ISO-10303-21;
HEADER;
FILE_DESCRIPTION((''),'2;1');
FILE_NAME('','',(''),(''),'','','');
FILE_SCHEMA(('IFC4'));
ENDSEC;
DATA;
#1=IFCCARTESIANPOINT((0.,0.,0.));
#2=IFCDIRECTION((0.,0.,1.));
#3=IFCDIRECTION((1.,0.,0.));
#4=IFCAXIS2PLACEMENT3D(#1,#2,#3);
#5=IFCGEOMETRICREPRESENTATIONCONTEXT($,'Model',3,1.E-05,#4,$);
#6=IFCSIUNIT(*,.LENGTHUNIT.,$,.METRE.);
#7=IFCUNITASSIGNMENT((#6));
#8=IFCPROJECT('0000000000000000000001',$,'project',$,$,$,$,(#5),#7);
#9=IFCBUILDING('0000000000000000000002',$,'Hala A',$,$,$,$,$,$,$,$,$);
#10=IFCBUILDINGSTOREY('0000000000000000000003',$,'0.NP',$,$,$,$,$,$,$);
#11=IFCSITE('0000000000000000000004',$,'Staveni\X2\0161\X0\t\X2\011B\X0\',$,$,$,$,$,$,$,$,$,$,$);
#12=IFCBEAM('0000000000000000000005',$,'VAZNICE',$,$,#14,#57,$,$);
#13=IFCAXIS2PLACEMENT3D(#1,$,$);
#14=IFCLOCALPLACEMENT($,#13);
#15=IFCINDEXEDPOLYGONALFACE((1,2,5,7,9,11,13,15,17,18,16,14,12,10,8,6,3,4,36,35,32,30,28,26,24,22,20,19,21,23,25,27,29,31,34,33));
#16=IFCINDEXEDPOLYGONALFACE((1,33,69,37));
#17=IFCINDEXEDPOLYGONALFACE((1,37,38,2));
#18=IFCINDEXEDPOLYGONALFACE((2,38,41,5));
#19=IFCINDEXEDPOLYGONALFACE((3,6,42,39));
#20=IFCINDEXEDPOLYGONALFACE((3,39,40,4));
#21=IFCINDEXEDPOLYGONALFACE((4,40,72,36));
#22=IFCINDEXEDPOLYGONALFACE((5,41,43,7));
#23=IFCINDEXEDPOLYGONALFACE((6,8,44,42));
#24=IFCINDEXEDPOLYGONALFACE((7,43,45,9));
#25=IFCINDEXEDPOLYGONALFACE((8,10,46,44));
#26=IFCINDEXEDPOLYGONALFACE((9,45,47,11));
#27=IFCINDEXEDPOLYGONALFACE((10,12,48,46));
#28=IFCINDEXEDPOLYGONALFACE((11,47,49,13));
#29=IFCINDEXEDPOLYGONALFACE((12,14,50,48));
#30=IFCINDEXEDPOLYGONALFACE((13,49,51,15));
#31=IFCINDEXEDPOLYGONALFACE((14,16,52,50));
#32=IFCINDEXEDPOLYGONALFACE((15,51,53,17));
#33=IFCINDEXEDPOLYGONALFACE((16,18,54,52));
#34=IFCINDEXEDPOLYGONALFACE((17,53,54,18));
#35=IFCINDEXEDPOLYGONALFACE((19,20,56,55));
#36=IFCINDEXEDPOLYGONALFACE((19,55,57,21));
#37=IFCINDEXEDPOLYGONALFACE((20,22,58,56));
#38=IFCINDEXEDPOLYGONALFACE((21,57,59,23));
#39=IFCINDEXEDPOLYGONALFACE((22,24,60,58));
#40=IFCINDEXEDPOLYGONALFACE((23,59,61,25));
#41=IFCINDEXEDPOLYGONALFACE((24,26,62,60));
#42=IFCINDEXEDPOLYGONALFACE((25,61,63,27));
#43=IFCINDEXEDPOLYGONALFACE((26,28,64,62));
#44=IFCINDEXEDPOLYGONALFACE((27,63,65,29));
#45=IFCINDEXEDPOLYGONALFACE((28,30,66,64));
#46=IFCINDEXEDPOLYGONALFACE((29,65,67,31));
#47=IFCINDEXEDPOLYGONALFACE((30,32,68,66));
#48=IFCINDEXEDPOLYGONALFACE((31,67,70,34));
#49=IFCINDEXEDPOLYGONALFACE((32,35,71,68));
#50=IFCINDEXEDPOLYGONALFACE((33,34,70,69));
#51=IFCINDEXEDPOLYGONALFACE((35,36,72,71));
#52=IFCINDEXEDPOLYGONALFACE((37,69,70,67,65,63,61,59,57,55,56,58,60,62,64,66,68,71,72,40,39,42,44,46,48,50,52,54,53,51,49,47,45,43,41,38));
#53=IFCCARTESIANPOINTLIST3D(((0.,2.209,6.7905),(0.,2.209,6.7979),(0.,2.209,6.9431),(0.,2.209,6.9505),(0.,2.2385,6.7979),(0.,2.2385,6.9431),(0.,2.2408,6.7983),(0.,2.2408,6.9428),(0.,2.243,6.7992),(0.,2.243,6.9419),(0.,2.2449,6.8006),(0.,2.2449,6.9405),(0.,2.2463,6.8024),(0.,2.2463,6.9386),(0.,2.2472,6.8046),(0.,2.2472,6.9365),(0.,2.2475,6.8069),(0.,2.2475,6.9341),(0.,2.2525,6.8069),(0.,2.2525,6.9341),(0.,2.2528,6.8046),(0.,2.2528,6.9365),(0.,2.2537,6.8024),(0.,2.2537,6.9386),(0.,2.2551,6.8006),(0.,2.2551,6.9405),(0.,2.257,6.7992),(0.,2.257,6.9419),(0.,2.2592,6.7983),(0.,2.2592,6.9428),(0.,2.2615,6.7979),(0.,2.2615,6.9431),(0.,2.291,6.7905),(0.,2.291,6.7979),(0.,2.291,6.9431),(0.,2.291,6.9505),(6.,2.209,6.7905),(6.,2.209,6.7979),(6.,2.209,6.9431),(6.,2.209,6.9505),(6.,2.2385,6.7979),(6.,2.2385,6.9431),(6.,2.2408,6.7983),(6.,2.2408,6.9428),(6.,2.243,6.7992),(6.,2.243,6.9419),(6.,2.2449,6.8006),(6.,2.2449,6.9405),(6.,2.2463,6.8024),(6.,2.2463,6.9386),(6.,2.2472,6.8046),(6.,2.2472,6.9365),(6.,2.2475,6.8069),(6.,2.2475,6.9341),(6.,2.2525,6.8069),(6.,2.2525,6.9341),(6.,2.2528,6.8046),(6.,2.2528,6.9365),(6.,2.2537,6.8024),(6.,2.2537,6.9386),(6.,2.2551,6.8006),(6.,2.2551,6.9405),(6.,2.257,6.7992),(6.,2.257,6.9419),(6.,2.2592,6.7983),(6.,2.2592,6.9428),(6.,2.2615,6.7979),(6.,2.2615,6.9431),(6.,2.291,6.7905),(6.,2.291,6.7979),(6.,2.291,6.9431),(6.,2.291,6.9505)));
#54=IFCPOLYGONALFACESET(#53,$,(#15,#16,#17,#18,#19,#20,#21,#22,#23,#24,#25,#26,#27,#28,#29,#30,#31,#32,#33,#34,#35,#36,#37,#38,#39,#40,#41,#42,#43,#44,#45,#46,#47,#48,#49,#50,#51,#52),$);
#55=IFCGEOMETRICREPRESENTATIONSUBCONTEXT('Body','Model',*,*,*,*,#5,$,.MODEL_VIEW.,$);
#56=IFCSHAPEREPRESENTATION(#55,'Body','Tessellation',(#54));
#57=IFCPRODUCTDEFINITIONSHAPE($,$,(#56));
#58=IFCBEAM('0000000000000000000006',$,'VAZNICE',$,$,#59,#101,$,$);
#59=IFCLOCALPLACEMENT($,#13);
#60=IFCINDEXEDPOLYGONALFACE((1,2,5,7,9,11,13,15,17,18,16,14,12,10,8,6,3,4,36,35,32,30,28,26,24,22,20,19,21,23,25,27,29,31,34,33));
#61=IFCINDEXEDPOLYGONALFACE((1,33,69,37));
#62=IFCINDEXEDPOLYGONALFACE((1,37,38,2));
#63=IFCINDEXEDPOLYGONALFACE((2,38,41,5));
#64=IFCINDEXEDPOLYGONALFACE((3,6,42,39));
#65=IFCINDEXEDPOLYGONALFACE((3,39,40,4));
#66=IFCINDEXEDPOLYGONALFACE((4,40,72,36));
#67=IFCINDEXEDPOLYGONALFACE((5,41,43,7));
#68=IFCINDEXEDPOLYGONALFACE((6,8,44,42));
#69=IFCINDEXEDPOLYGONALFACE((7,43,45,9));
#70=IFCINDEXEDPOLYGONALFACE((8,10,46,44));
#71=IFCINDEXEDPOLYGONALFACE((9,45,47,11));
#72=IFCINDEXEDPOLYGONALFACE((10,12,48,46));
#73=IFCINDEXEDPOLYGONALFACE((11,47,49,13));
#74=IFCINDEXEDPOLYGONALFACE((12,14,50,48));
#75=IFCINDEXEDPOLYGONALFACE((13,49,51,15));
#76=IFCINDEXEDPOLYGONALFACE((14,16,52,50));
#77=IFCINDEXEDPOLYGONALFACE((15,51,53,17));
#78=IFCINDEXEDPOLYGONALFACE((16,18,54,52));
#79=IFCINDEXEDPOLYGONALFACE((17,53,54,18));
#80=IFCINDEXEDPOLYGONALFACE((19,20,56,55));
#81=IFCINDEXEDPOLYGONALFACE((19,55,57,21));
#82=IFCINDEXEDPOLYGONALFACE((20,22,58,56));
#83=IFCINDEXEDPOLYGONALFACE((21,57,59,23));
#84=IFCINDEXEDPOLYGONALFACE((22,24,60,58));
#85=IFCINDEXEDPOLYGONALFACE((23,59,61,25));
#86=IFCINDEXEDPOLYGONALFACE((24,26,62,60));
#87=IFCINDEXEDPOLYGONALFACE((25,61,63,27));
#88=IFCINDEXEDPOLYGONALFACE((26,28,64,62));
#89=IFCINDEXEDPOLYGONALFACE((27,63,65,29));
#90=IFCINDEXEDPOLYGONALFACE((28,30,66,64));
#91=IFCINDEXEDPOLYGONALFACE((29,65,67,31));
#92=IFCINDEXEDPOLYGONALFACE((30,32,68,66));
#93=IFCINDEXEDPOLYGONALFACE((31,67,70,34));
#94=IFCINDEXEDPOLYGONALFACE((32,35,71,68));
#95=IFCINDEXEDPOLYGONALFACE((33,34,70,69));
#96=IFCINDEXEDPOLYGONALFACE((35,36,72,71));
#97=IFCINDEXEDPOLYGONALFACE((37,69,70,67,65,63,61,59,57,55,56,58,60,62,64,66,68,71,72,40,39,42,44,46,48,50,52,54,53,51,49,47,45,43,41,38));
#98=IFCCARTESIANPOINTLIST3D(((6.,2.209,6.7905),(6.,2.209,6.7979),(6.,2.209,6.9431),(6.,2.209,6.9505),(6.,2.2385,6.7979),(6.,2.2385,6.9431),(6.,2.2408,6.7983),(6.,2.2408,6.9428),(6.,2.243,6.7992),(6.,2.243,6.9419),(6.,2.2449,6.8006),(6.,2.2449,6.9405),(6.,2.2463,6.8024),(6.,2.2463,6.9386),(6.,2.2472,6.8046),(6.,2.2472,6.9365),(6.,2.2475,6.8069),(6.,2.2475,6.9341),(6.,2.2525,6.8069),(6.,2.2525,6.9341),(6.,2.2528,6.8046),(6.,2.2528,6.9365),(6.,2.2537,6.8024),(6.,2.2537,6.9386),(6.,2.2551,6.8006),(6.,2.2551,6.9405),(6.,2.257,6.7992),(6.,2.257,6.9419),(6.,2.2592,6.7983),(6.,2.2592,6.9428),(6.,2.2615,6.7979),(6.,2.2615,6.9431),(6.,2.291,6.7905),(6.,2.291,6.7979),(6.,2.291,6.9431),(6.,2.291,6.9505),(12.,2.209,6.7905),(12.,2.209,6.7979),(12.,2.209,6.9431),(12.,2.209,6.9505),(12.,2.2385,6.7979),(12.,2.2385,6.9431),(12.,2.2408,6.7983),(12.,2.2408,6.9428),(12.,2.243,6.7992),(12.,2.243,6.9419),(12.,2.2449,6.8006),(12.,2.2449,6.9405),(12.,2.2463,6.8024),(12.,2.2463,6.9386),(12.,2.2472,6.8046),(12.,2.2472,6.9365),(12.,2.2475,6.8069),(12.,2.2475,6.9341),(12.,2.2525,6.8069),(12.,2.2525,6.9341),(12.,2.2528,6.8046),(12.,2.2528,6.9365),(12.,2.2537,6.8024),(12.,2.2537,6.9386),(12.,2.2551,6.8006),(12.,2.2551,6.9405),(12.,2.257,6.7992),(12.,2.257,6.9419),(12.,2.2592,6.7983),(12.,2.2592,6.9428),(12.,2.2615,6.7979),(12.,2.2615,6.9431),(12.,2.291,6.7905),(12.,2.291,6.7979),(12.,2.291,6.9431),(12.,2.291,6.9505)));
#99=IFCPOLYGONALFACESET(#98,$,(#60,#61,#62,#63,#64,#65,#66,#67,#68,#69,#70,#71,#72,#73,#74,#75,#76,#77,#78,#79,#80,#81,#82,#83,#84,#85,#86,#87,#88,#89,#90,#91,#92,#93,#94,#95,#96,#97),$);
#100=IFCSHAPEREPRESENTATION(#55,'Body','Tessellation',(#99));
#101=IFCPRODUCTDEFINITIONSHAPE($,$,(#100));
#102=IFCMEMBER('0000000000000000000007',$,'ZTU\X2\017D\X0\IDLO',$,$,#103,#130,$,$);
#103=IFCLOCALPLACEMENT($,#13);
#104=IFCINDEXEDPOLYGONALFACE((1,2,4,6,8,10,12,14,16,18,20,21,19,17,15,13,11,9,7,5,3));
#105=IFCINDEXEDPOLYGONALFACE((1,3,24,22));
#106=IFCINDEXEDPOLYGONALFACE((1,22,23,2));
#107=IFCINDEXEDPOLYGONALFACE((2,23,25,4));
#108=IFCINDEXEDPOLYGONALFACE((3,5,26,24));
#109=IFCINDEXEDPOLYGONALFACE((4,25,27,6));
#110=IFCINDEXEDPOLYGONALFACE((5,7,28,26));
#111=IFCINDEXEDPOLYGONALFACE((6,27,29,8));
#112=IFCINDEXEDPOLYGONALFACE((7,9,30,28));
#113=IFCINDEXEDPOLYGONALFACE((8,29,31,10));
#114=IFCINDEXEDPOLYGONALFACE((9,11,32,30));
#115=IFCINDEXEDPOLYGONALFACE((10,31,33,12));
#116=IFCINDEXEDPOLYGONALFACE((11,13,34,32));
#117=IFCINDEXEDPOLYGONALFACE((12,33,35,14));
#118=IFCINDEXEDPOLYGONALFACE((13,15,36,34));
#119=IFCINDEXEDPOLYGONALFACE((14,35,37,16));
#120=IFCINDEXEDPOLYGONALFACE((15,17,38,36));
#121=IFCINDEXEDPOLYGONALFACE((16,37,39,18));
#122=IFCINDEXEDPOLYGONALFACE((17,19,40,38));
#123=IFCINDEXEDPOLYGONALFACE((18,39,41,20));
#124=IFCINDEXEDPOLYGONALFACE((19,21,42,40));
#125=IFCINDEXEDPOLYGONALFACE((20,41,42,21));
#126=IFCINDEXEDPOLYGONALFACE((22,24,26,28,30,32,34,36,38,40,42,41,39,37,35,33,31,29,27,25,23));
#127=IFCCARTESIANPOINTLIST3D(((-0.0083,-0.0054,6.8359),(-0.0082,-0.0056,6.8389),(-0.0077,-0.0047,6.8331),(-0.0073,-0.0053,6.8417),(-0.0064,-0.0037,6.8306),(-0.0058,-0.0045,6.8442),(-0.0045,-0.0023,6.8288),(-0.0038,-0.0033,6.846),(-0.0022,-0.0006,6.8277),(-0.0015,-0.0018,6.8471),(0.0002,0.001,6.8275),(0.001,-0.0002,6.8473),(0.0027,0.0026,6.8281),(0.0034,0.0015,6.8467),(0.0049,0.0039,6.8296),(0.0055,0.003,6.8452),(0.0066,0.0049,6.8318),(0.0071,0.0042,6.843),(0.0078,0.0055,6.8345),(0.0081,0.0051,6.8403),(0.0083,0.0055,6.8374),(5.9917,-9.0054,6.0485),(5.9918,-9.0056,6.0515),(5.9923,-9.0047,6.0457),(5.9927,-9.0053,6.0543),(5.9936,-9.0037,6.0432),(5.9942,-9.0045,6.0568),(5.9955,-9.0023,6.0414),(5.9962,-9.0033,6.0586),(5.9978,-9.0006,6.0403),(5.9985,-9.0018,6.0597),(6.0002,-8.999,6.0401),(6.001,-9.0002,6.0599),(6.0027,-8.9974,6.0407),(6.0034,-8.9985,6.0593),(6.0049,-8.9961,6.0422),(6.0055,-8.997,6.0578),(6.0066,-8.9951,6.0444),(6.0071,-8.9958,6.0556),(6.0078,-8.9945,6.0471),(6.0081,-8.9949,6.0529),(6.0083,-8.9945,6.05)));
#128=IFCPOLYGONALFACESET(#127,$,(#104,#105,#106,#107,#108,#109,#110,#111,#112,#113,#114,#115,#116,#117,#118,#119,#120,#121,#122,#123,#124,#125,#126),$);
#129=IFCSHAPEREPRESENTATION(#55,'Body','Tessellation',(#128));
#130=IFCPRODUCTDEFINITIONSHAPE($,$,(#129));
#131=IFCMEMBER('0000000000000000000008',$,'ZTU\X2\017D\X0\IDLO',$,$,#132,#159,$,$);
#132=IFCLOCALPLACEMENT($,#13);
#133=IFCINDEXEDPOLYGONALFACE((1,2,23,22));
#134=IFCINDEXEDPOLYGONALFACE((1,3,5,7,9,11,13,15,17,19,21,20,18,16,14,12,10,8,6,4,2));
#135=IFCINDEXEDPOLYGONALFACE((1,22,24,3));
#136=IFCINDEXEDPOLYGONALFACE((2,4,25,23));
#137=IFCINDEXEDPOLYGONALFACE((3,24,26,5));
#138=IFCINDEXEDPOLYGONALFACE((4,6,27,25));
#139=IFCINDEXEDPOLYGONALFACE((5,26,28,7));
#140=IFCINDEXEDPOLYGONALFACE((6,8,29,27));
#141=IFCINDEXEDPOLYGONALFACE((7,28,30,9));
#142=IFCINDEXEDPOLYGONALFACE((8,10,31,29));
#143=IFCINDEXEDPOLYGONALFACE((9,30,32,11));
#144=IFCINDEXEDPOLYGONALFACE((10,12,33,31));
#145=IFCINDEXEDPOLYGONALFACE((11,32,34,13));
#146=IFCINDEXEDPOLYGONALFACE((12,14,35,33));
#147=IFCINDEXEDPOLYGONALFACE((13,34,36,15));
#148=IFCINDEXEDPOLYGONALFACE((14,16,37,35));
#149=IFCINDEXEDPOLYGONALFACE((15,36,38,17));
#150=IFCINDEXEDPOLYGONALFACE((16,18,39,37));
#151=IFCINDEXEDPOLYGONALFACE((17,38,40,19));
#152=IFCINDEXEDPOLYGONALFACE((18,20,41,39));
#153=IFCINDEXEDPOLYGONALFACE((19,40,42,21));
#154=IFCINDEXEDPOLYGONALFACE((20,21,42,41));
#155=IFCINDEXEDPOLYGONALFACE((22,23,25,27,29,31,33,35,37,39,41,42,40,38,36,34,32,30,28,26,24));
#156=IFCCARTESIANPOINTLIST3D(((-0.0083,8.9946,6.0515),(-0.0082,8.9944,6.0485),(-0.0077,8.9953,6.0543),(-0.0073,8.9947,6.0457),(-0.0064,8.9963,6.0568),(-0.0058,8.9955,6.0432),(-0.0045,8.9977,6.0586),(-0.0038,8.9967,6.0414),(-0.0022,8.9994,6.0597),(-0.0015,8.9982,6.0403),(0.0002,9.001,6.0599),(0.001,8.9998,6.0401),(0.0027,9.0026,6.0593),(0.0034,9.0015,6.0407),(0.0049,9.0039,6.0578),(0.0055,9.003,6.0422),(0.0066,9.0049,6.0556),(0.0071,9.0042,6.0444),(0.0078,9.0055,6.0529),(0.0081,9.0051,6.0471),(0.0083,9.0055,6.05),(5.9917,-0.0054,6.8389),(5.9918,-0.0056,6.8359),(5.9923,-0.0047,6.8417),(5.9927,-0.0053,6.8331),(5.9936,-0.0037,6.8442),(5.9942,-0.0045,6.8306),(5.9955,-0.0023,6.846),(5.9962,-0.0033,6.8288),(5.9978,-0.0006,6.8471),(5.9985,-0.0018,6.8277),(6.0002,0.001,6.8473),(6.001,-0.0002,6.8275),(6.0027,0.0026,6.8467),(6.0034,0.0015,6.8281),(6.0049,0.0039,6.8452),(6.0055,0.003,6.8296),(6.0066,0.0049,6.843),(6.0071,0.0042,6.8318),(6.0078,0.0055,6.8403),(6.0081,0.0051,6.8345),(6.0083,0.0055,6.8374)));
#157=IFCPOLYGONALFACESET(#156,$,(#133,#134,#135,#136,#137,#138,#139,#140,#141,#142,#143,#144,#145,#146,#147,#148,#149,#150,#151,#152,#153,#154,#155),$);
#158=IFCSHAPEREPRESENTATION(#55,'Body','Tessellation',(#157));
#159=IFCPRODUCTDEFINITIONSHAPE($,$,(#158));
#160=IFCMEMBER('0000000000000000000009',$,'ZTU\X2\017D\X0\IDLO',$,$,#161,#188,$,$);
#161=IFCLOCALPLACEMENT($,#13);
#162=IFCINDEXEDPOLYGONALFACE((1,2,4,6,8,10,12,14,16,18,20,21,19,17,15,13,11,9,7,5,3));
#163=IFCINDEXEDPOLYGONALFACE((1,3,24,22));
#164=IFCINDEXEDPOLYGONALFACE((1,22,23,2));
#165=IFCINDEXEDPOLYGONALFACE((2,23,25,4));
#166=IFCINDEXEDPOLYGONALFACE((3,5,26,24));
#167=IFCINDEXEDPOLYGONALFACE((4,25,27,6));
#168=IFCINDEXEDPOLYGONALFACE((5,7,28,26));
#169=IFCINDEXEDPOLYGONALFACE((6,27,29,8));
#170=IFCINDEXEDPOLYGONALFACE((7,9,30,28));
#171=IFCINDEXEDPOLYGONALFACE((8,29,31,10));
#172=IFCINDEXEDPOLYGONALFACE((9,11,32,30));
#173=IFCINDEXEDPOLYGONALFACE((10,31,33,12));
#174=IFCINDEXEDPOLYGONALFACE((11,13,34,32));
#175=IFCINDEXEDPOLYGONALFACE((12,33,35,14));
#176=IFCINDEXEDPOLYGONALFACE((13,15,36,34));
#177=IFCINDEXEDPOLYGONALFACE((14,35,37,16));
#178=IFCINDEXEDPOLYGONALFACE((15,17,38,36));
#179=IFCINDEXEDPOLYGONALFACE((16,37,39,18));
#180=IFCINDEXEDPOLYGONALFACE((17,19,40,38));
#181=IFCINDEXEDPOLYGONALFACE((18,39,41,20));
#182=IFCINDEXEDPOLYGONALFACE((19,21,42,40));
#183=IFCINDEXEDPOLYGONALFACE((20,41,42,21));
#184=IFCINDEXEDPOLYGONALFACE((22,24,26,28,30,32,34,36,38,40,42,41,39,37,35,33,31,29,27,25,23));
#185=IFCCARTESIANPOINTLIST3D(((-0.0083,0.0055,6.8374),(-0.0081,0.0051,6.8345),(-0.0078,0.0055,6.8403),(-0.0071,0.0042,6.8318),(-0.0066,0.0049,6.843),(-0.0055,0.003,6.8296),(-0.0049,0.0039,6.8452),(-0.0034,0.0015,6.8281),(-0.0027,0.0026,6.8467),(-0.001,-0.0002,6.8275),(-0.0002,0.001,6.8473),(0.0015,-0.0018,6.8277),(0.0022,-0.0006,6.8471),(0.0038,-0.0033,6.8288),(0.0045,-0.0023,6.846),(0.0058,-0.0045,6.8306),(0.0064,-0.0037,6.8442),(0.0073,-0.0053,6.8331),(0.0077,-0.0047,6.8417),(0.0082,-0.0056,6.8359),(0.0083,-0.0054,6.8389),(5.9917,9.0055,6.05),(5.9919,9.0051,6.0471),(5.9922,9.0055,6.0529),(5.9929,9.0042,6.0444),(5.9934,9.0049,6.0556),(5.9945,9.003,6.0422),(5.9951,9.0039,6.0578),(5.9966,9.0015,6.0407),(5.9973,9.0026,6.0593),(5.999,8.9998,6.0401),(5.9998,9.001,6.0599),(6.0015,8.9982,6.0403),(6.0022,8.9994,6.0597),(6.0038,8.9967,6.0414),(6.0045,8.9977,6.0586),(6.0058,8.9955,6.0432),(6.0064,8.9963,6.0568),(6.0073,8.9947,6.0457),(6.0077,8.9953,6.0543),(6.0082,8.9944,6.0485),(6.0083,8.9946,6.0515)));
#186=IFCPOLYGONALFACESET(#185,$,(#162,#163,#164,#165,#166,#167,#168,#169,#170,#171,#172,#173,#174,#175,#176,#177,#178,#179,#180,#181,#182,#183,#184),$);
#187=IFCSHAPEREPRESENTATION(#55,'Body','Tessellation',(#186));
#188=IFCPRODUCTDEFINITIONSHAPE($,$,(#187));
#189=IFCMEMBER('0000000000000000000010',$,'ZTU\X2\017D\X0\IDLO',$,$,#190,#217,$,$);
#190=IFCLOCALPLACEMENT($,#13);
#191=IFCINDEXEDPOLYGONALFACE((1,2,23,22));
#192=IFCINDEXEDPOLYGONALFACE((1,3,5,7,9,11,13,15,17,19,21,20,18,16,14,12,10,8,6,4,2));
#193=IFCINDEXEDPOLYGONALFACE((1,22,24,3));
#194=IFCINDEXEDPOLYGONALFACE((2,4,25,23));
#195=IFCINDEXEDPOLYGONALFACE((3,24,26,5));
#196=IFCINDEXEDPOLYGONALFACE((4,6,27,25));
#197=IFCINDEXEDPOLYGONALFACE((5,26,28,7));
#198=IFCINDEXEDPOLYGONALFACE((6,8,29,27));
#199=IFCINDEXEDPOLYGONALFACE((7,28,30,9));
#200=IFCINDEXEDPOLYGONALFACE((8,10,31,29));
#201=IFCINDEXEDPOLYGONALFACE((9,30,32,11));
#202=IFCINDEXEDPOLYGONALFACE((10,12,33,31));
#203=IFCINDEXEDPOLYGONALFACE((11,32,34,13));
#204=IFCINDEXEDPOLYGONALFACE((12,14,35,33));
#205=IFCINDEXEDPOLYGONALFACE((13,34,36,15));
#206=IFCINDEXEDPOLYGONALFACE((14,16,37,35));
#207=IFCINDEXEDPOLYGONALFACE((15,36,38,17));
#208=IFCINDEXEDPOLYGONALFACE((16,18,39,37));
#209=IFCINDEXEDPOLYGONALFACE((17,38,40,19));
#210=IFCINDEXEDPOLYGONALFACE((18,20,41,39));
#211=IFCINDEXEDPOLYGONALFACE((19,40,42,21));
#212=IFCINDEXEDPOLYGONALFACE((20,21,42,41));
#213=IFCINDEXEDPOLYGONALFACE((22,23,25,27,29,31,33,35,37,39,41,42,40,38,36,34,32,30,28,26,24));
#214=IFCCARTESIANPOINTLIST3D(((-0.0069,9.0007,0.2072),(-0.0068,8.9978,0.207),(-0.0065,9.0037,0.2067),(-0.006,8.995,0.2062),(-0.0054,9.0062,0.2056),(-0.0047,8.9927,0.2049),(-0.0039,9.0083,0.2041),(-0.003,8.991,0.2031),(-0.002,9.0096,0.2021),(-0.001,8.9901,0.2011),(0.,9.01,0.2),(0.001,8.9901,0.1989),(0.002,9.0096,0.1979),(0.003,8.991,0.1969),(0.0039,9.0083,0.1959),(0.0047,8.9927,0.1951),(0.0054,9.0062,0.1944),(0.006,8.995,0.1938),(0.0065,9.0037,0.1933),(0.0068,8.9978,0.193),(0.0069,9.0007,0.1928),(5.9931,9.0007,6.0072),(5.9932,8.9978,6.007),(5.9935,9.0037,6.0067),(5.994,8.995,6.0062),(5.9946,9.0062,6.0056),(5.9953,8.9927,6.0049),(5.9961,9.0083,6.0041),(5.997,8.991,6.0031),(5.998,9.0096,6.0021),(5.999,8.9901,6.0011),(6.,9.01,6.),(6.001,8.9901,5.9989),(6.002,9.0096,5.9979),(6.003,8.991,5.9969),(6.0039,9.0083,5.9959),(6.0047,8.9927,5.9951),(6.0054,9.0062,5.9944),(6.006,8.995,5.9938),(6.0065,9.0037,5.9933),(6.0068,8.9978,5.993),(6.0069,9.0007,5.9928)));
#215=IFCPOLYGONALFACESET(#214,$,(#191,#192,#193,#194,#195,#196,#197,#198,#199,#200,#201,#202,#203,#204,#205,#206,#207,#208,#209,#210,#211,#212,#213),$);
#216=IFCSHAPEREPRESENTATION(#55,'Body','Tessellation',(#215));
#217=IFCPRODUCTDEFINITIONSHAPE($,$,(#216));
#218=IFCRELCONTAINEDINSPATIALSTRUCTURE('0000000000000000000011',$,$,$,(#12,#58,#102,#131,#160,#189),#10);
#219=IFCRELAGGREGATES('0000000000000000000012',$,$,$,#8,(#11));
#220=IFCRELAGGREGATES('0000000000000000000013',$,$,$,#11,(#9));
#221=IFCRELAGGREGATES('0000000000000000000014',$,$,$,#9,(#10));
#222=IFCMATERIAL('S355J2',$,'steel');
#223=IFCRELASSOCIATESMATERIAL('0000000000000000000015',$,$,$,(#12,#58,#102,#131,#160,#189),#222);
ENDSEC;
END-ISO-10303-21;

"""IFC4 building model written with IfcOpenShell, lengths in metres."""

from ifc_helpers import new_model, si_unit, frame, origin_with_axes, place, context, subcontext, project, spatial, circle, i_section, extrude, material, element, save


model = new_model("IFC4")

# Units and contexts
model_context = context("Model", 3, precision=1e-05, world=origin_with_axes())
body_context = subcontext(model_context, "Body", "Model", "MODEL_VIEW")
ifc_project = project(units=[si_unit("LENGTHUNIT", "METRE")], contexts=[model_context])

# Site, building, storey
site = spatial("IfcSite", under=ifc_project, Name="Staveniště")
building = spatial("IfcBuilding", under=site, Name="Hala A")
storey = spatial("IfcBuildingStorey", under=building, Name="0.NP")

# Shared definitions
ifc_material = material(Name="S355J2", Category="steel")

# Beams
for number, where, z_axis, x_axis, name in (
    (1, (0.0, 2.25, 6.8705), (1.0, 0.0, 0.0), (0.0, 1.0, 0.0), "VAZNICE"),
    (2, (6.0, 2.25, 6.8705), (1.0, 0.0, 0.0), (0.0, 1.0, 0.0), "VAZNICE"),
):
    element("IfcBeam", number, at=place(None, frame(where, z_axis=z_axis, x_axis=x_axis)), inside=storey, material=ifc_material, Name=name, context=body_context, shape_type="SweptSolid", body=[
        extrude(i_section(OverallWidth=0.082, OverallDepth=0.16, WebThickness=0.005, FlangeThickness=0.0074, FilletRadius=0.009), origin_with_axes(), (0.0, 0.0, 1.0), 6.0),
    ])

# Members
for number, where, z_axis, x_axis, name in (
    (3, (0.0, 0.0, 6.8374), (0.553236, -0.829854, -0.072603), (0.83205, 0.5547, 0.0), "ZTUŽIDLO"),
    (4, (0.0, 9.0, 6.05), (0.553236, -0.829854, 0.072603), (0.83205, 0.5547, 0.0), "ZTUŽIDLO"),
    (5, (0.0, 0.0, 6.8374), (0.553236, 0.829854, -0.072603), (-0.83205, 0.5547, 0.0), "ZTUŽIDLO"),
):
    element("IfcMember", number, at=place(None, frame(where, z_axis=z_axis, x_axis=x_axis)), inside=storey, material=ifc_material, Name=name, context=body_context, shape_type="SweptSolid", body=[
        extrude(circle(Radius=0.01), origin_with_axes(), (0.0, 0.0, 1.0), 10.8453),
    ])
for number, where, z_axis, x_axis, name in (
    (6, (0.0, 9.0, 0.2), (0.718988, 0.0, 0.695022), (0.0, 1.0, 0.0), "ZTUŽIDLO"),
):
    element("IfcMember", number, at=place(None, frame(where, z_axis=z_axis, x_axis=x_axis)), inside=storey, material=ifc_material, Name=name, context=body_context, shape_type="SweptSolid", body=[
        extrude(circle(Radius=0.01), origin_with_axes(), (0.0, 0.0, 1.0), 8.3451),
    ])

save(model, "model.ifc")
